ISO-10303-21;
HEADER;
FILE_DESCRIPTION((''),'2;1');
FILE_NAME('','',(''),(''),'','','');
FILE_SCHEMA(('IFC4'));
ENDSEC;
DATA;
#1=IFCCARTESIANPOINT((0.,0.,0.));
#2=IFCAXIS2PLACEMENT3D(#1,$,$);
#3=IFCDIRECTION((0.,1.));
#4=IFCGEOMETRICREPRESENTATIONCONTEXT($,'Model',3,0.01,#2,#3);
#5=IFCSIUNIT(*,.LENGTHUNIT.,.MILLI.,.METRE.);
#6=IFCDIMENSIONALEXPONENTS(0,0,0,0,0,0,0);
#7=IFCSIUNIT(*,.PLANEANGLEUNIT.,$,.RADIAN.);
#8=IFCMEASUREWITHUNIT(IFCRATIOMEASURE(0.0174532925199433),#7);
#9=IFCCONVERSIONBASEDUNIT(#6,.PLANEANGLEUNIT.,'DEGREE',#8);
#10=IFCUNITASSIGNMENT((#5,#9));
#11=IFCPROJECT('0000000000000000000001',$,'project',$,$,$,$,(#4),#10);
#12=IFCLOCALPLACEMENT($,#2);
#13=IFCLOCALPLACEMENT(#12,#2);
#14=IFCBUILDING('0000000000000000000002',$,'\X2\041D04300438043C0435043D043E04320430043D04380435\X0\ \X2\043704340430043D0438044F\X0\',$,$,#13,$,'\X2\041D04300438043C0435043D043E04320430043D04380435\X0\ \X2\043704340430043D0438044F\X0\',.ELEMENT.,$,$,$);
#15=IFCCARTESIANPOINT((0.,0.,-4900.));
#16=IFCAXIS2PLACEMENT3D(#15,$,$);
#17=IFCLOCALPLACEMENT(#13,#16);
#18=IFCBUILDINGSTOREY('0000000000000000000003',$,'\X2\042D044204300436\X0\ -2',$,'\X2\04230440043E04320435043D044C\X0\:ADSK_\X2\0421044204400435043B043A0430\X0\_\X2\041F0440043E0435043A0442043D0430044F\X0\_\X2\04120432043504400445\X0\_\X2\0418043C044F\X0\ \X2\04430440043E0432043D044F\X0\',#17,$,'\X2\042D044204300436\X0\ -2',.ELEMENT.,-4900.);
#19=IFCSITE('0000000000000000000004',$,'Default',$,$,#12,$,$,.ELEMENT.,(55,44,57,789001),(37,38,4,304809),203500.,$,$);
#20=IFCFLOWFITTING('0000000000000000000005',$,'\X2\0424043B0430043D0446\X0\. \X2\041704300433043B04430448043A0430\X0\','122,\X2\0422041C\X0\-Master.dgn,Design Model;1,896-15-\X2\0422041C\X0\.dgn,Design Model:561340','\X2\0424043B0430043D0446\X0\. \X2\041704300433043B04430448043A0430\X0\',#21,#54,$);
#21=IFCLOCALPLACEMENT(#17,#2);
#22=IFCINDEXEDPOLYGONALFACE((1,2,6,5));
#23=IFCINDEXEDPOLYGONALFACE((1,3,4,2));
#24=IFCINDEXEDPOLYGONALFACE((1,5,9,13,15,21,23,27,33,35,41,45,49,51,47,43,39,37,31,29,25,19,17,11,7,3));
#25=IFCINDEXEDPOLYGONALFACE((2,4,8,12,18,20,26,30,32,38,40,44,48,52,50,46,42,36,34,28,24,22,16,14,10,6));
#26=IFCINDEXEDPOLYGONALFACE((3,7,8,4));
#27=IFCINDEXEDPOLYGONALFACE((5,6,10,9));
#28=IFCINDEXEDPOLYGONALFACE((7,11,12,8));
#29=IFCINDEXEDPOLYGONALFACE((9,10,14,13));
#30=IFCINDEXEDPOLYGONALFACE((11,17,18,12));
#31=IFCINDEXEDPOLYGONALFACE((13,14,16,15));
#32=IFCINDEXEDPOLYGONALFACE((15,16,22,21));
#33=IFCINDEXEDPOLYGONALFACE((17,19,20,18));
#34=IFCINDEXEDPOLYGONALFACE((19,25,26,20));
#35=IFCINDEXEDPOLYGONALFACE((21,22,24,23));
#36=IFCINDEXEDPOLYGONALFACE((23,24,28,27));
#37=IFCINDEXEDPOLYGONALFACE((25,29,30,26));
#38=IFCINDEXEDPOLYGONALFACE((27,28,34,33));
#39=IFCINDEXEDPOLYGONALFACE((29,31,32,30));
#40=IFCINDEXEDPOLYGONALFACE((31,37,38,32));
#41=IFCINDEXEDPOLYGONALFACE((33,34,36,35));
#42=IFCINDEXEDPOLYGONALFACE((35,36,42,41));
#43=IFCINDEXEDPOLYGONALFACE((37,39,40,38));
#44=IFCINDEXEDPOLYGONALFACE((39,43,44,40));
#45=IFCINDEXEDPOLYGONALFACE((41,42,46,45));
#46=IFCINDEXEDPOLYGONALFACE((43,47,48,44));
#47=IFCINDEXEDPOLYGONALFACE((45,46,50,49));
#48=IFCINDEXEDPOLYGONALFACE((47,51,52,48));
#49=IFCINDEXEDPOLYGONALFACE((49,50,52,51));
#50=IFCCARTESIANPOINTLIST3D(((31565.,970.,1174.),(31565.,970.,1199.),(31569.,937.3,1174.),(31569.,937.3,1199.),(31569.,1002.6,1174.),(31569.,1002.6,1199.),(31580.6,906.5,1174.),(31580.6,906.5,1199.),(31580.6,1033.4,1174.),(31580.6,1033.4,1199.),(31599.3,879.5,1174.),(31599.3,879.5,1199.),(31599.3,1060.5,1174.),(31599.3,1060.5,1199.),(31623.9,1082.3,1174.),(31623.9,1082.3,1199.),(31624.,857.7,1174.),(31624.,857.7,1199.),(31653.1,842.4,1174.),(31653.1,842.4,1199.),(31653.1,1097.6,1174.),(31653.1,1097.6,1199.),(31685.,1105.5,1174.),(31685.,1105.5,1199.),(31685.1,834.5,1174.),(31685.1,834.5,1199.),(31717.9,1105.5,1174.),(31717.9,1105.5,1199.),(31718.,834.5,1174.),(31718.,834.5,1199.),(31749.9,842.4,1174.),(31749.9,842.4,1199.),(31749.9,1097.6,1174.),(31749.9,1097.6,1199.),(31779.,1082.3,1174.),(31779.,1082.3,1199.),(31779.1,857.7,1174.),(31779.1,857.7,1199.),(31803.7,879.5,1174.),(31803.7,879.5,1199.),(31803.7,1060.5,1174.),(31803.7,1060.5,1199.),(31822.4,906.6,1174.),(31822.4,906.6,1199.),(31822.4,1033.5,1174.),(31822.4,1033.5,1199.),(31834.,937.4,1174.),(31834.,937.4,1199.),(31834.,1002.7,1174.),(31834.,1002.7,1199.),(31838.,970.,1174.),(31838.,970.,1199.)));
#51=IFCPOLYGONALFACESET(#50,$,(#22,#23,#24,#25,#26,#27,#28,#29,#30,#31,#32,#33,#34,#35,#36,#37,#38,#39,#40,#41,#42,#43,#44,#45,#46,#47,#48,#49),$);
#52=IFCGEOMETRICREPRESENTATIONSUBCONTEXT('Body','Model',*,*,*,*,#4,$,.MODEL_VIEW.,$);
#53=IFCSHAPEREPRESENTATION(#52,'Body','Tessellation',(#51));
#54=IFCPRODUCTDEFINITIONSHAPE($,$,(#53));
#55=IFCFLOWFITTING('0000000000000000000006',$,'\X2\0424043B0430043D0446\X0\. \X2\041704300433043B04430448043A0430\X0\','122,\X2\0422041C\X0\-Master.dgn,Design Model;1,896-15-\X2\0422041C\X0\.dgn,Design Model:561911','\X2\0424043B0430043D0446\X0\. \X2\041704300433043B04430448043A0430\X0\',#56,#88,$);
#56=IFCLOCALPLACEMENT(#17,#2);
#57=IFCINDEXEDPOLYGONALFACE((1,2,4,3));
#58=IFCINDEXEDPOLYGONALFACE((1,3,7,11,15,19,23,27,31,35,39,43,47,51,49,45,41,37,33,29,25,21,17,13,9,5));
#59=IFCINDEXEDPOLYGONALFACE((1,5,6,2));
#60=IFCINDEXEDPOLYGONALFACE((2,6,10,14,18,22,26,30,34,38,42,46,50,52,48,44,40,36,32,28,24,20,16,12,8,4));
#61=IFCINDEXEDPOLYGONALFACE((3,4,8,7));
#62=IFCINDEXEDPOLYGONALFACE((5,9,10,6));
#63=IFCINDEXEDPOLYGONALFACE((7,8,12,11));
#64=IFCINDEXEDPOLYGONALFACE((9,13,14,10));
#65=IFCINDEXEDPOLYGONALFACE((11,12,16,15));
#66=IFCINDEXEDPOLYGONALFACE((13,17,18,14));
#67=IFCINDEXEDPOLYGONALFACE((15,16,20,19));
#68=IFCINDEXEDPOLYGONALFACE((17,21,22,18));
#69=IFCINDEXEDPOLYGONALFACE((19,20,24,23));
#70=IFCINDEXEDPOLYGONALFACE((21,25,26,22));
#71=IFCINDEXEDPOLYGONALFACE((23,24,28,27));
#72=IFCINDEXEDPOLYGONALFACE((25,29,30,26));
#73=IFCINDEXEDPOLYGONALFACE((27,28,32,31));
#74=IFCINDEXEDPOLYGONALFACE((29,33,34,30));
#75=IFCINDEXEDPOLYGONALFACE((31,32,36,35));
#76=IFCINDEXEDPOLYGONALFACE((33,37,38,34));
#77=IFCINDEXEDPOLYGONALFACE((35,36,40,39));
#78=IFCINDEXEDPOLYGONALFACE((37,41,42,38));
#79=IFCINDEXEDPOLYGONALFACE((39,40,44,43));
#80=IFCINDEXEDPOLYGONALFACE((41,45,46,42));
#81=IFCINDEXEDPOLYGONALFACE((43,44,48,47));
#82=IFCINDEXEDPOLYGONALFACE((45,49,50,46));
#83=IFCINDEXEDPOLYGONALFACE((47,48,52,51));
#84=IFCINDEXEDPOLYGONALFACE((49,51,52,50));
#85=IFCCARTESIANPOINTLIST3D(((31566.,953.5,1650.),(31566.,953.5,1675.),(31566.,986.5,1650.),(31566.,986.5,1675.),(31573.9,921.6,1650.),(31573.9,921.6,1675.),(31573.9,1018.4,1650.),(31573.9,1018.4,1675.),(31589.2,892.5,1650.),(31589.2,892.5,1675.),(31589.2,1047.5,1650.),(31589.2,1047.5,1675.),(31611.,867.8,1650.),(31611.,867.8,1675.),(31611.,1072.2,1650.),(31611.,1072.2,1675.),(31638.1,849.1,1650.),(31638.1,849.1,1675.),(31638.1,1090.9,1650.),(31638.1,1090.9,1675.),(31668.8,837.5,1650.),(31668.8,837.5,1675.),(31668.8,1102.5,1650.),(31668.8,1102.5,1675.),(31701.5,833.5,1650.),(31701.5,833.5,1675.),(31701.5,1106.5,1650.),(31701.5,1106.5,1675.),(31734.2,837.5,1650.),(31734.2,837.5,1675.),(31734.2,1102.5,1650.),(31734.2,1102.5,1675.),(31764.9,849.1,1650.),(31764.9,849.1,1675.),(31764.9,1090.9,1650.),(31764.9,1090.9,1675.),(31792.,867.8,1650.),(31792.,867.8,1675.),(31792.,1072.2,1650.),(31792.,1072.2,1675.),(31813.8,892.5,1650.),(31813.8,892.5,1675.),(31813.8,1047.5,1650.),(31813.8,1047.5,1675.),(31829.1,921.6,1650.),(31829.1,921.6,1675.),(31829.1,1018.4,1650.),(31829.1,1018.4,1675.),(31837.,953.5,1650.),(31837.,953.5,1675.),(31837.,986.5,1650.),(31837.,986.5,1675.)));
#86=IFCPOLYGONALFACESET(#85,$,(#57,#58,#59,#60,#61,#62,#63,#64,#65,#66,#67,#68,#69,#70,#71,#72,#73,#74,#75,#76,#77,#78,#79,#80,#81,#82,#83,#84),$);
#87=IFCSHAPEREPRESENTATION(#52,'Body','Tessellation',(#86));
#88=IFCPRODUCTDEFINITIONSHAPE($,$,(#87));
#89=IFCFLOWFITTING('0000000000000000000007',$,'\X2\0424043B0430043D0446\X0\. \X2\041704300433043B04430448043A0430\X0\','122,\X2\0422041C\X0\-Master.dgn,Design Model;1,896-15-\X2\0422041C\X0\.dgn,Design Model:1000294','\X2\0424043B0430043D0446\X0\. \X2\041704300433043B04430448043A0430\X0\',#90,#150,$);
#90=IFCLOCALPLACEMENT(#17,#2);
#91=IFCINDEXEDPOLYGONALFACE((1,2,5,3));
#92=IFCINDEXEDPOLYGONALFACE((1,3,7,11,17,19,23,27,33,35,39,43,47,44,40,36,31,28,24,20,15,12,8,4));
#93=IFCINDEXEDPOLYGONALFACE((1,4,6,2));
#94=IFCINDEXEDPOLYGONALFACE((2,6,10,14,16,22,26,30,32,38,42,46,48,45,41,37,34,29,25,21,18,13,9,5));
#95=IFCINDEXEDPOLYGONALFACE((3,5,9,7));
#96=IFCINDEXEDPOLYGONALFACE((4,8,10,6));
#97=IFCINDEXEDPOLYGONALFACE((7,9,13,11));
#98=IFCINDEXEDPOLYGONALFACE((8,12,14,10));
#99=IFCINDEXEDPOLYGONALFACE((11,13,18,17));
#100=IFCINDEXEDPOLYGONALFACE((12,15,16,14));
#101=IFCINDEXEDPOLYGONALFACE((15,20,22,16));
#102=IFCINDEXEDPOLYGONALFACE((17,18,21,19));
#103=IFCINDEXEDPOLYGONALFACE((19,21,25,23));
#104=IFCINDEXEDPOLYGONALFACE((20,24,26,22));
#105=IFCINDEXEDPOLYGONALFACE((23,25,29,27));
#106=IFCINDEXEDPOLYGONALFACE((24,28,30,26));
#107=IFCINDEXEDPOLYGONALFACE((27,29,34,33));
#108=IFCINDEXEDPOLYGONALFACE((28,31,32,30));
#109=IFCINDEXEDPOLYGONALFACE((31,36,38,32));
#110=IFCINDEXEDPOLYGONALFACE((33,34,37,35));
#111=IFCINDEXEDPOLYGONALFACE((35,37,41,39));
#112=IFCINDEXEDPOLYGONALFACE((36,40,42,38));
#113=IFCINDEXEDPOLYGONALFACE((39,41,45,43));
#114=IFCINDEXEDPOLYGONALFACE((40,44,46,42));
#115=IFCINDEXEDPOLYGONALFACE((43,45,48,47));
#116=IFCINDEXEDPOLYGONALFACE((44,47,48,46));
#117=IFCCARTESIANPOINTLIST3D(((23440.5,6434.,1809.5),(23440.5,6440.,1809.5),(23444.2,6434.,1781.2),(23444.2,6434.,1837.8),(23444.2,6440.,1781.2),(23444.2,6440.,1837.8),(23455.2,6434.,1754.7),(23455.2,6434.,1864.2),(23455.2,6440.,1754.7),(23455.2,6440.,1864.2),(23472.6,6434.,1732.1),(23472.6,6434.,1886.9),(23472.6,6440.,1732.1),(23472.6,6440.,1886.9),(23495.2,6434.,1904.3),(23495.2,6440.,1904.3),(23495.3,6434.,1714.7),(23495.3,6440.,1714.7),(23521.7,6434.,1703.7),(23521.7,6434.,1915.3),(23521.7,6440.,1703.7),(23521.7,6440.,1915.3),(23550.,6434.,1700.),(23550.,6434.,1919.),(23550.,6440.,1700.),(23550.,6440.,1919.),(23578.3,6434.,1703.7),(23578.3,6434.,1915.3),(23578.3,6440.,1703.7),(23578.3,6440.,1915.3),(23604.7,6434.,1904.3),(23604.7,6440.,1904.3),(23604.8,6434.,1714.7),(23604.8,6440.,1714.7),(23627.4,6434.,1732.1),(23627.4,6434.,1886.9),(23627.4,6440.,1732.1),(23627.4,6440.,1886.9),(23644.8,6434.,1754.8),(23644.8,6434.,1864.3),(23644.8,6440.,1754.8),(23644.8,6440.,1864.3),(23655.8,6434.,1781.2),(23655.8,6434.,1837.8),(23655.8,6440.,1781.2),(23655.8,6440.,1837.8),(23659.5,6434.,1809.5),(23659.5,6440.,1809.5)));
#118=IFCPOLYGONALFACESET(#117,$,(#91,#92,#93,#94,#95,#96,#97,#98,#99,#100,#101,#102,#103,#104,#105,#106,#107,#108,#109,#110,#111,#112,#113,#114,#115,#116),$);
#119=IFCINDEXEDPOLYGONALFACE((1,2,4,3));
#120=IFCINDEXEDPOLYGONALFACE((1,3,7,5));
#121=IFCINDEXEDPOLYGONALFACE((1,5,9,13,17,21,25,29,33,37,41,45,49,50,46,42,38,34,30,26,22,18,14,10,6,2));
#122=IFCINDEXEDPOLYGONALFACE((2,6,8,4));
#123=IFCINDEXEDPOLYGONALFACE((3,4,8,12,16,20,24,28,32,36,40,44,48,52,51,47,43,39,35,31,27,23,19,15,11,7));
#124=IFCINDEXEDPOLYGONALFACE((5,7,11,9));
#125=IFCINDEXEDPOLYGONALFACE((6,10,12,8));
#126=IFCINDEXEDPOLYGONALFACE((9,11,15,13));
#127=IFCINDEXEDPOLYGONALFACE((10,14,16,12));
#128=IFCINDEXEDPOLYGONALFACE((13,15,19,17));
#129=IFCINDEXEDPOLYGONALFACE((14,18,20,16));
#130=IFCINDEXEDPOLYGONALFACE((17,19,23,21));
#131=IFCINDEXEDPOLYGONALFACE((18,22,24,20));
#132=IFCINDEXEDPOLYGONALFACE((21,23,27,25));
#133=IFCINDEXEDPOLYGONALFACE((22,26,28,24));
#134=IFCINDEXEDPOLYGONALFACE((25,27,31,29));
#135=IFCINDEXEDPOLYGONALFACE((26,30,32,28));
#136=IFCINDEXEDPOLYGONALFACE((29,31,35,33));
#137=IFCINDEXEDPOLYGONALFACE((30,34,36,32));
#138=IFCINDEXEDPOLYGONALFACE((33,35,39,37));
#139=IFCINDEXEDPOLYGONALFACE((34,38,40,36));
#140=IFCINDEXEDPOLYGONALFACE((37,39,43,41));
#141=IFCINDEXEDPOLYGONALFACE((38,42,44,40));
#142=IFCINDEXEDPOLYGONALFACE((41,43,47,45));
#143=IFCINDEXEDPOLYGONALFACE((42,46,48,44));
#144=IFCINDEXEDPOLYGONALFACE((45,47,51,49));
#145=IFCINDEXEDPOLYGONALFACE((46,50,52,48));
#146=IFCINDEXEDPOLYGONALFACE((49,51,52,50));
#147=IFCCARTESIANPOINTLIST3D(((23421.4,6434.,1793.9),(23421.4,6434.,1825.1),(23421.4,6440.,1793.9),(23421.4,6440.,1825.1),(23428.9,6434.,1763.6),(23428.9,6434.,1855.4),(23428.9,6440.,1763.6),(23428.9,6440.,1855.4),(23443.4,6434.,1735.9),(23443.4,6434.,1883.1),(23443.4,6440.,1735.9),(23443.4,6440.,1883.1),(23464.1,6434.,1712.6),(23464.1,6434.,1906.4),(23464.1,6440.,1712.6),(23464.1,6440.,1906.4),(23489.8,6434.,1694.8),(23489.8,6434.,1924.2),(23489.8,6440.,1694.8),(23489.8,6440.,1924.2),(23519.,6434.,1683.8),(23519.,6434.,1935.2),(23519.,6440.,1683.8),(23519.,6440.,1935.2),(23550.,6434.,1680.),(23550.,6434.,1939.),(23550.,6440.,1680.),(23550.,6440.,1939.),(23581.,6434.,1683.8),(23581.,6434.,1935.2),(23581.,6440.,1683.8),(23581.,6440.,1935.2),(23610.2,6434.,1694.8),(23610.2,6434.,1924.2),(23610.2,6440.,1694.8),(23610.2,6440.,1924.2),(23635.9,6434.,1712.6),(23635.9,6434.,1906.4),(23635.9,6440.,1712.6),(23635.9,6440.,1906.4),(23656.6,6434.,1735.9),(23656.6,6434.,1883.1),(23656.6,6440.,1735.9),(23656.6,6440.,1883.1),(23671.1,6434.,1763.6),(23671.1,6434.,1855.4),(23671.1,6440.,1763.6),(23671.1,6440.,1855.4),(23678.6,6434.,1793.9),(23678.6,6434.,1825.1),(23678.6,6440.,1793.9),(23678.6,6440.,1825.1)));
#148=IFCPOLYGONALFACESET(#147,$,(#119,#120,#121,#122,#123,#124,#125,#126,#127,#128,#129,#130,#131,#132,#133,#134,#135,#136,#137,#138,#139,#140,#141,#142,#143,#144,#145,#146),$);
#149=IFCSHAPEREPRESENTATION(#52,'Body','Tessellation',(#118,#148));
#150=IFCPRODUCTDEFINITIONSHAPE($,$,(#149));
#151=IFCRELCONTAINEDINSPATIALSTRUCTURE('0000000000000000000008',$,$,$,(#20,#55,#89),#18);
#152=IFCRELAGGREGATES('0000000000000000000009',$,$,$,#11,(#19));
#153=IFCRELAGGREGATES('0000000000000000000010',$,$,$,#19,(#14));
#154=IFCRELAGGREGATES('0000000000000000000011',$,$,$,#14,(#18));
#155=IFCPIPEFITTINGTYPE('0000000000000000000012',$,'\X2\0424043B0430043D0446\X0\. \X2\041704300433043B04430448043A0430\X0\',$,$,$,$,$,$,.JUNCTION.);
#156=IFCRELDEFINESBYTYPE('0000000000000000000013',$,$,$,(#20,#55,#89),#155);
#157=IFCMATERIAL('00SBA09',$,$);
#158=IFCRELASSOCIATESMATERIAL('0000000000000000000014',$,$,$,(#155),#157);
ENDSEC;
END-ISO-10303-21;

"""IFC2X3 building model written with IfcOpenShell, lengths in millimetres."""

from ifc_helpers import new_model, entity, si_unit, converted_unit, direction, frame, origin, place, context, subcontext, project, spatial, polyline, outline, extrude, material, type_object, element, save


model = new_model("IFC2X3")

# Units and contexts
model_context = context("Model", 3, precision=0.01, world=origin(), true_north=direction((0.0, 1.0)))
body_context = subcontext(model_context, "Body", "Model", "MODEL_VIEW")
ifc_project = project(units=[si_unit("LENGTHUNIT", "METRE", prefix="MILLI"), converted_unit("PLANEANGLEUNIT", "DEGREE", entity("IfcRatioMeasure", 0.0174532925199433), si_unit("PLANEANGLEUNIT", "RADIAN"), dimensions=[0, 0, 0, 0, 0, 0, 0])], contexts=[model_context])

# Site, building, storey
site_placement = place(None, origin())
site = spatial("IfcSite", under=ifc_project, at=site_placement, Name="Default", CompositionType="ELEMENT", RefLatitude=(55, 44, 57, 789001), RefLongitude=(37, 38, 4, 304809), RefElevation=203500.0)
building_placement = place(site_placement, origin())
building = spatial("IfcBuilding", under=site, at=building_placement, Name="Наименование здания", LongName="Наименование здания", CompositionType="ELEMENT")
storey_placement = place(building_placement, frame((0.0, 0.0, -4900.0)))
storey = spatial("IfcBuildingStorey", under=building, at=storey_placement, Name="Этаж -2", ObjectType="Уровень:ADSK_Стрелка_Проектная_Вверх_Имя уровня", LongName="Этаж -2", CompositionType="ELEMENT", Elevation=-4900.0)

# Flow fittings
ifc_material_1 = material(Name="00SBA09")
pipe_fitting_type_1 = type_object("IfcPipeFittingType", Name="Фланц. Заглушка", PredefinedType="JUNCTION", material=ifc_material_1)
flow_fitting_1_placement = place(storey_placement, frame((31565.0, 834.5, 1174.0)))
element("IfcFlowFitting", 1, at=flow_fitting_1_placement, inside=storey, type_object=pipe_fitting_type_1, Name="Фланц. Заглушка", Description="122,ТМ-Master.dgn,Design Model;1,896-15-ТМ.dgn,Design Model:561340", ObjectType="Фланц. Заглушка", context=body_context, shape_type="SweptSolid", body=[
    extrude(outline(polyline([(-16.4, -135.5), (16.4, -135.5), (48.4, -127.6), (77.5, -112.3), (102.2, -90.5), (120.9, -63.4), (132.5, -32.7), (136.5, 0.0), (132.5, 32.7), (120.9, 63.4), (102.2, 90.5), (77.5, 112.3), (48.4, 127.6), (16.4, 135.5), (-16.4, 135.5), (-48.4, 127.6), (-77.5, 112.3), (-102.2, 90.5), (-120.9, 63.4), (-132.5, 32.7), (-136.5, 0.0), (-132.5, -32.7), (-120.9, -63.4), (-102.2, -90.5), (-77.5, -112.3), (-48.4, -127.6), (-16.4, -135.5)])), frame((136.5, 135.5, 0.0), z_axis=(0.0, 0.0, 1.0), x_axis=(0.748599, -0.663023, 0.0)), (0.0, 0.0, 1.0), 25.0),
])
flow_fitting_2_placement = place(storey_placement, frame((31566.0, 833.5, 1650.0)))
element("IfcFlowFitting", 2, at=flow_fitting_2_placement, inside=storey, type_object=pipe_fitting_type_1, Name="Фланц. Заглушка", Description="122,ТМ-Master.dgn,Design Model;1,896-15-ТМ.dgn,Design Model:561911", ObjectType="Фланц. Заглушка", context=body_context, shape_type="SweptSolid", body=[
    extrude(outline(polyline([(-16.4, -135.5), (16.4, -135.5), (48.4, -127.6), (77.5, -112.3), (102.2, -90.5), (120.9, -63.4), (132.5, -32.7), (136.5, 0.0), (132.5, 32.7), (120.9, 63.4), (102.2, 90.5), (77.5, 112.3), (48.4, 127.6), (16.4, 135.5), (-16.4, 135.5), (-48.4, 127.6), (-77.5, 112.3), (-102.2, 90.5), (-120.9, 63.4), (-132.5, 32.7), (-136.5, 0.0), (-132.5, -32.7), (-120.9, -63.4), (-102.2, -90.5), (-77.5, -112.3), (-48.4, -127.6), (-16.4, -135.5)])), frame((135.5, 136.5, 0.0), z_axis=(0.0, 0.0, 1.0), x_axis=(-0.992709, -0.120537, 0.0)), (0.0, 0.0, 1.0), 25.0),
])
flow_fitting_3_placement = place(storey_placement, frame((23421.4, 6434.0, 1680.0)))
element("IfcFlowFitting", 3, at=flow_fitting_3_placement, inside=storey, type_object=pipe_fitting_type_1, Name="Фланц. Заглушка", Description="122,ТМ-Master.dgn,Design Model;1,896-15-ТМ.dgn,Design Model:1000294", ObjectType="Фланц. Заглушка", context=body_context, shape_type="SweptSolid", body=[
    extrude(outline(polyline([(-14.3, -108.6), (14.3, -108.6), (41.9, -101.2), (66.7, -86.9), (86.9, -66.7), (101.2, -41.9), (108.6, -14.3), (108.6, 14.3), (101.2, 41.9), (86.9, 66.7), (66.7, 86.9), (41.9, 101.2), (14.3, 108.6), (-14.3, 108.6), (-41.9, 101.2), (-66.7, 86.9), (-86.9, 66.7), (-101.2, 41.9), (-108.6, 14.3), (-108.6, -14.3), (-101.2, -41.9), (-86.9, -66.7), (-66.7, -86.9), (-41.9, -101.2), (-14.3, -108.6)])), frame((128.6, 0.0, 129.5), z_axis=(0.0, 1.0, 0.0), x_axis=(0.991445, 0.0, -0.130526)), (0.0, 0.0, 1.0), 6.0),
    extrude(outline(polyline([(-15.6, -128.6), (15.6, -128.6), (45.9, -121.1), (73.6, -106.6), (96.9, -85.9), (114.7, -60.2), (125.7, -31.0), (129.5, 0.0), (125.7, 31.0), (114.7, 60.2), (96.9, 85.9), (73.6, 106.6), (45.9, 121.1), (15.6, 128.6), (-15.6, 128.6), (-45.9, 121.1), (-73.6, 106.6), (-96.9, 85.9), (-114.7, 60.2), (-125.7, 31.0), (-129.5, 0.0), (-125.7, -31.0), (-114.7, -60.2), (-96.9, -85.9), (-73.6, -106.6), (-45.9, -121.1), (-15.6, -128.6)])), frame((128.6, 0.0, 129.5), z_axis=(0.0, 1.0, 0.0), x_axis=(0.992709, 0.0, -0.120537)), (0.0, 0.0, 1.0), 6.0),
])

save(model, "model.ifc")
